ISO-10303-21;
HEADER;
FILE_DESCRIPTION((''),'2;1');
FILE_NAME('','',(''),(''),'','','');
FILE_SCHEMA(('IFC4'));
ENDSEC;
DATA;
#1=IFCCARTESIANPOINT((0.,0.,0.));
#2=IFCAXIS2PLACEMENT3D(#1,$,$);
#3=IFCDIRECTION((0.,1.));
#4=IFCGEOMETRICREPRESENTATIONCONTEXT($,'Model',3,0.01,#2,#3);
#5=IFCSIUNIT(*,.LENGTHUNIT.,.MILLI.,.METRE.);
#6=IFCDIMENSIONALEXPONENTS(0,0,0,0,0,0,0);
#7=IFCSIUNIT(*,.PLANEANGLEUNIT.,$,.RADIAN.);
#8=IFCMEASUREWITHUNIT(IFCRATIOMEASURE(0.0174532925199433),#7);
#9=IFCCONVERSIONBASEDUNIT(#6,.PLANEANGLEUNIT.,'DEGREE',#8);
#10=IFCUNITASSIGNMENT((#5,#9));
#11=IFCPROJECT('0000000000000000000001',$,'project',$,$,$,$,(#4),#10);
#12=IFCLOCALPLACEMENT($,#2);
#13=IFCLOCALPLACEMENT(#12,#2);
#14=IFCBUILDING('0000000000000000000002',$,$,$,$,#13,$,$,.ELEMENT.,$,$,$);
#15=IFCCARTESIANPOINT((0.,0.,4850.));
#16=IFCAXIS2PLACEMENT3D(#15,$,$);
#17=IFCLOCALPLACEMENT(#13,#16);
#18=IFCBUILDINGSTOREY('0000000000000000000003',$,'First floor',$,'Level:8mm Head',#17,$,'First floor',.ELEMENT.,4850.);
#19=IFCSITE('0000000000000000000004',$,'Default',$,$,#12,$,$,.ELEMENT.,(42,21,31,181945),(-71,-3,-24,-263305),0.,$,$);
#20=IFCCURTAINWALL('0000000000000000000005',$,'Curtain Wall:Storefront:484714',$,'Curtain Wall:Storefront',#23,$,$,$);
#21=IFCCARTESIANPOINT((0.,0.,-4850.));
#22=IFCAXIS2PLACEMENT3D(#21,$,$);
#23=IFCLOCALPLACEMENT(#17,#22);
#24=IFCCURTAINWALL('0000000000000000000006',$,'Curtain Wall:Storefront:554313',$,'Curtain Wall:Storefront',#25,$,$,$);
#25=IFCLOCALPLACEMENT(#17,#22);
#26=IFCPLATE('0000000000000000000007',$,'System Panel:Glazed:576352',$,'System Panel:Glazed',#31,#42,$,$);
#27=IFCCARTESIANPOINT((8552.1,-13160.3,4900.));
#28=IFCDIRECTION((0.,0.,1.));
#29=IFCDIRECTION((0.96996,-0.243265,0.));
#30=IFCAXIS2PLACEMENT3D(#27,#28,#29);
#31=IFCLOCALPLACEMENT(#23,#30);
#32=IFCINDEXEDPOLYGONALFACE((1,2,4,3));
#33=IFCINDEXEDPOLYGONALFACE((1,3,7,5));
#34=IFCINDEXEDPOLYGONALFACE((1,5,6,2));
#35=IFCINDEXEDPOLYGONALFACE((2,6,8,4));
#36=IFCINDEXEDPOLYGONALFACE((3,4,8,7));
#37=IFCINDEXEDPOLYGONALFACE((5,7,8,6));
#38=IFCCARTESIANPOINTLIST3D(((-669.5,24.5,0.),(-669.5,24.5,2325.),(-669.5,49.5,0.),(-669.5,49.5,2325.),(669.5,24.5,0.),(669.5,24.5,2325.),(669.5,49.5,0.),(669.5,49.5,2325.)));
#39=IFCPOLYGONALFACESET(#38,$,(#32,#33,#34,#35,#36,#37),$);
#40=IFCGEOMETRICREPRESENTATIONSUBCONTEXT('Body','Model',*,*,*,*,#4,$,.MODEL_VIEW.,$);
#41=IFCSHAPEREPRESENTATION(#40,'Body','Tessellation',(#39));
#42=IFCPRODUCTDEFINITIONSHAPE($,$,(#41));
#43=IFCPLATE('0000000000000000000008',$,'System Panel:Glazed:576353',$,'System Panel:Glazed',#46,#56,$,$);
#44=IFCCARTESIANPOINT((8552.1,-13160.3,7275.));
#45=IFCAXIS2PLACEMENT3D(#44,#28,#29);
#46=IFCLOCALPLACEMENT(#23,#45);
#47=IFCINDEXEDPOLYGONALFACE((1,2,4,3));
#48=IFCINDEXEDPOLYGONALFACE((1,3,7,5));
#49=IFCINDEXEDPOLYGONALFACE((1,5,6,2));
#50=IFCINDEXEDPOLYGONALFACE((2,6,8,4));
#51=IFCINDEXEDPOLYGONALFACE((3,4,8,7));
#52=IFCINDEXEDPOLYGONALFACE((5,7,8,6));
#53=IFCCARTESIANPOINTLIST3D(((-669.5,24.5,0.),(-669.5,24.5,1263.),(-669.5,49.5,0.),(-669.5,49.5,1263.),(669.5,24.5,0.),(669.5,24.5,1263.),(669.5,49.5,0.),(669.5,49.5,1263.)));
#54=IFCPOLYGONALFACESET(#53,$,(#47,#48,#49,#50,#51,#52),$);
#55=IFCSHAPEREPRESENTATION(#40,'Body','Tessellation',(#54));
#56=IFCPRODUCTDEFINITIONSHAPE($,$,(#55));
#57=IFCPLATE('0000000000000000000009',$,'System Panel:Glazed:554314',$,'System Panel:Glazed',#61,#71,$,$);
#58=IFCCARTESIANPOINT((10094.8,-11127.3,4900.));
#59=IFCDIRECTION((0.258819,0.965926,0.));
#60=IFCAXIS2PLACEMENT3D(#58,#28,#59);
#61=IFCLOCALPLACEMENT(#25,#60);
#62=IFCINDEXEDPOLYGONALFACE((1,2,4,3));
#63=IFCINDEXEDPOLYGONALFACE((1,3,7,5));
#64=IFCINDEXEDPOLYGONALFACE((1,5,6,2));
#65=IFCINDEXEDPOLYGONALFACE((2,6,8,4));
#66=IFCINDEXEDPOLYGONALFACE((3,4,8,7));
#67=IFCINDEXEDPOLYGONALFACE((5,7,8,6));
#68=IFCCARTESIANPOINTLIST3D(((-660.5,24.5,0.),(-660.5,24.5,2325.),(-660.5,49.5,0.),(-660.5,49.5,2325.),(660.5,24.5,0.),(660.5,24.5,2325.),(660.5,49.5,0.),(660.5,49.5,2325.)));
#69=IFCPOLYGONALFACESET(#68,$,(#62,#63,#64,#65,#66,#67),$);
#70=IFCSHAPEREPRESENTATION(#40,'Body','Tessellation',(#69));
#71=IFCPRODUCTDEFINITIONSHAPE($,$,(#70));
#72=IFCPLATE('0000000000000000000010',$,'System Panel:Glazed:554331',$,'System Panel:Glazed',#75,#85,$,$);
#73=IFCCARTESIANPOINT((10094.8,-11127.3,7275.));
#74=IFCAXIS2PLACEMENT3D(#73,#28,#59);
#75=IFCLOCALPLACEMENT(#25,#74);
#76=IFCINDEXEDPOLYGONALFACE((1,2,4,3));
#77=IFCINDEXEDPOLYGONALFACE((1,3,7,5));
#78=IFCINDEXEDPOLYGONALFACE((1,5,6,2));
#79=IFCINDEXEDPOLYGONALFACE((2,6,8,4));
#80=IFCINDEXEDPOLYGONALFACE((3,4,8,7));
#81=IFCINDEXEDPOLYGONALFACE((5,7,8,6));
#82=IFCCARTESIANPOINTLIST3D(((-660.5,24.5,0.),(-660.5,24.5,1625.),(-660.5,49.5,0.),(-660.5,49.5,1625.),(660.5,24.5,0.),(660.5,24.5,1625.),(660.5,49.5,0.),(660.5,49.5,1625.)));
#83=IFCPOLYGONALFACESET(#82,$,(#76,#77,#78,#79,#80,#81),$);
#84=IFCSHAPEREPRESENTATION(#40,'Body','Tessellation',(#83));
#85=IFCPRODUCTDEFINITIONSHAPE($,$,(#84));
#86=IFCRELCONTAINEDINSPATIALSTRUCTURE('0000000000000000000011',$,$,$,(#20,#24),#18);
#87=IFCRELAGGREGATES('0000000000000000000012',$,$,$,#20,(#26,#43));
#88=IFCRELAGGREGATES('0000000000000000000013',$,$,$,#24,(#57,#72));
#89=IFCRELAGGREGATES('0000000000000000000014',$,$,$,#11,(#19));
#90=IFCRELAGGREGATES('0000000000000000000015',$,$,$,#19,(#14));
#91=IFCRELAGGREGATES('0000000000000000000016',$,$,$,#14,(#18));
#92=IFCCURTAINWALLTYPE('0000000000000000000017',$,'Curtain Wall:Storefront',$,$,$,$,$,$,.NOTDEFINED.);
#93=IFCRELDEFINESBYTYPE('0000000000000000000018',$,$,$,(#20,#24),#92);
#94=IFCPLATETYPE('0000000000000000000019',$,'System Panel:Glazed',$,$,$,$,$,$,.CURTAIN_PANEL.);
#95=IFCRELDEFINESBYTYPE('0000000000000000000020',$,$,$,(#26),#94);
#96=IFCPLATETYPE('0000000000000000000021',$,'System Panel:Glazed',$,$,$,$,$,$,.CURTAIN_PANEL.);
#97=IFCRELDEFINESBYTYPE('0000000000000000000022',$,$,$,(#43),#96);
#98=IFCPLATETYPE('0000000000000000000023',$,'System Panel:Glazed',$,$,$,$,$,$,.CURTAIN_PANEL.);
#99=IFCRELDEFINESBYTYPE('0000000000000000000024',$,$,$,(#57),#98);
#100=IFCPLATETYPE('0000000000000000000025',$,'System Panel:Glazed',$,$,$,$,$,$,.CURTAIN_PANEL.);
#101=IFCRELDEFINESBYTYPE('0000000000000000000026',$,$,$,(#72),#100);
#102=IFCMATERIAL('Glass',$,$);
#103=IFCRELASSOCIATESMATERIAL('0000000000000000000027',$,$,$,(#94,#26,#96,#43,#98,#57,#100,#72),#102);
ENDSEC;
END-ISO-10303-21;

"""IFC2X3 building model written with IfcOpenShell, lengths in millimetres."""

from ifc_helpers import new_model, entity, si_unit, converted_unit, direction, frame, frame_2d, origin, place, context, subcontext, project, spatial, rectangle, extrude, source, transform, mapped, material, type_object, type_shapes, element, aggregate, save


model = new_model("IFC2X3")

# Units and contexts
model_context = context("Model", 3, precision=0.01, world=origin(), true_north=direction((0.0, 1.0)))
body_context = subcontext(model_context, "Body", "Model", "MODEL_VIEW")
ifc_project = project(units=[si_unit("LENGTHUNIT", "METRE", prefix="MILLI"), converted_unit("PLANEANGLEUNIT", "DEGREE", entity("IfcRatioMeasure", 0.0174532925199433), si_unit("PLANEANGLEUNIT", "RADIAN"), dimensions=[0, 0, 0, 0, 0, 0, 0])], contexts=[model_context])

# Site, building, storey
site_placement = place(None, origin())
site = spatial("IfcSite", under=ifc_project, at=site_placement, Name="Default", CompositionType="ELEMENT", RefLatitude=(42, 21, 31, 181945), RefLongitude=(-71, -3, -24, -263305), RefElevation=0.0)
building_placement = place(site_placement, origin())
building = spatial("IfcBuilding", under=site, at=building_placement, CompositionType="ELEMENT")
storey_placement = place(building_placement, frame((0.0, 0.0, 4850.0)))
storey = spatial("IfcBuildingStorey", under=building, at=storey_placement, Name="First floor", ObjectType="Level:8mm Head", LongName="First floor", CompositionType="ELEMENT", Elevation=4850.0)

# Curtain wall
curtain_wall_type = type_object("IfcCurtainWallType", Name="Curtain Wall:Storefront", PredefinedType="NOTDEFINED")
curtain_wall_1_placement = place(storey_placement, frame((0.0, 0.0, -4850.0)))
curtain_wall_1 = element("IfcCurtainWall", 1, at=curtain_wall_1_placement, inside=storey, type_object=curtain_wall_type, Name="Curtain Wall:Storefront:484714", ObjectType="Curtain Wall:Storefront")

# Curtain wall
curtain_wall_2_placement = place(storey_placement, frame((0.0, 0.0, -4850.0)))
curtain_wall_2 = element("IfcCurtainWall", 2, at=curtain_wall_2_placement, inside=storey, type_object=curtain_wall_type, Name="Curtain Wall:Storefront:554313", ObjectType="Curtain Wall:Storefront")

# Plates
ifc_material_1 = material(Name="Glass")
plate_type_1 = type_object("IfcPlateType", Name="System Panel:Glazed", PredefinedType="CURTAIN_PANEL", material=ifc_material_1)
shared_shape_1 = source(origin(), body_context, "Body", "SweptSolid", [
    extrude(rectangle(XDim=25.0, YDim=1339.1, at=frame_2d((0.0, 0.0), x_axis=(1.0, 0.0))), frame((0.0, 37.0, 0.0), z_axis=(0.0, 0.0, 1.0), x_axis=(0.0, 1.0, 0.0)), (0.0, 0.0, 1.0), 2325.0),
])
type_shapes(plate_type_1, [shared_shape_1])
plate_1_placement = place(curtain_wall_1_placement, frame((8552.1, -13160.3, 4900.0), z_axis=(0.0, 0.0, 1.0), x_axis=(0.96996, -0.243265, 0.0)))
plate_1 = element("IfcPlate", 3, at=plate_1_placement, type_object=plate_type_1, material=ifc_material_1, Name="System Panel:Glazed:576352", ObjectType="System Panel:Glazed", context=body_context, shape_type="MappedRepresentation", body=[
    mapped(shared_shape_1, transform((0.0, 0.0, 0.0), scale=1.0)),
])
plate_type_2 = type_object("IfcPlateType", Name="System Panel:Glazed", PredefinedType="CURTAIN_PANEL", material=ifc_material_1)
shared_shape_2 = source(origin(), body_context, "Body", "SweptSolid", [
    extrude(rectangle(XDim=25.0, YDim=1339.1, at=frame_2d((0.0, 0.0), x_axis=(1.0, 0.0))), frame((0.0, 37.0, 0.0), z_axis=(0.0, 0.0, 1.0), x_axis=(0.0, 1.0, 0.0)), (0.0, 0.0, 1.0), 1263.0),
])
type_shapes(plate_type_2, [shared_shape_2])
plate_2_placement = place(curtain_wall_1_placement, frame((8552.1, -13160.3, 7275.0), z_axis=(0.0, 0.0, 1.0), x_axis=(0.96996, -0.243265, 0.0)))
plate_2 = element("IfcPlate", 4, at=plate_2_placement, type_object=plate_type_2, material=ifc_material_1, Name="System Panel:Glazed:576353", ObjectType="System Panel:Glazed", context=body_context, shape_type="MappedRepresentation", body=[
    mapped(shared_shape_2, transform((0.0, 0.0, 0.0), scale=1.0)),
])
aggregate(curtain_wall_1, [plate_1, plate_2])
plate_type_3 = type_object("IfcPlateType", Name="System Panel:Glazed", PredefinedType="CURTAIN_PANEL", material=ifc_material_1)
shared_shape_3 = source(origin(), body_context, "Body", "SweptSolid", [
    extrude(rectangle(XDim=25.0, YDim=1321.1, at=frame_2d((0.0, 0.0), x_axis=(1.0, 0.0))), frame((0.0, 37.0, 0.0), z_axis=(0.0, 0.0, 1.0), x_axis=(0.0, 1.0, 0.0)), (0.0, 0.0, 1.0), 2325.0),
])
type_shapes(plate_type_3, [shared_shape_3])
plate_3_placement = place(curtain_wall_2_placement, frame((10094.8, -11127.3, 4900.0), z_axis=(0.0, 0.0, 1.0), x_axis=(0.258819, 0.965926, 0.0)))
plate_3 = element("IfcPlate", 5, at=plate_3_placement, type_object=plate_type_3, material=ifc_material_1, Name="System Panel:Glazed:554314", ObjectType="System Panel:Glazed", context=body_context, shape_type="MappedRepresentation", body=[
    mapped(shared_shape_3, transform((0.0, 0.0, 0.0), scale=1.0)),
])
plate_type_4 = type_object("IfcPlateType", Name="System Panel:Glazed", PredefinedType="CURTAIN_PANEL", material=ifc_material_1)
shared_shape_4 = source(origin(), body_context, "Body", "SweptSolid", [
    extrude(rectangle(XDim=25.0, YDim=1321.1, at=frame_2d((0.0, 0.0), x_axis=(1.0, 0.0))), frame((0.0, 37.0, 0.0), z_axis=(0.0, 0.0, 1.0), x_axis=(0.0, 1.0, 0.0)), (0.0, 0.0, 1.0), 1625.0),
])
type_shapes(plate_type_4, [shared_shape_4])
plate_4_placement = place(curtain_wall_2_placement, frame((10094.8, -11127.3, 7275.0), z_axis=(0.0, 0.0, 1.0), x_axis=(0.258819, 0.965926, 0.0)))
plate_4 = element("IfcPlate", 6, at=plate_4_placement, type_object=plate_type_4, material=ifc_material_1, Name="System Panel:Glazed:554331", ObjectType="System Panel:Glazed", context=body_context, shape_type="MappedRepresentation", body=[
    mapped(shared_shape_4, transform((0.0, 0.0, 0.0), scale=1.0)),
])
aggregate(curtain_wall_2, [plate_3, plate_4])

save(model, "model.ifc")
